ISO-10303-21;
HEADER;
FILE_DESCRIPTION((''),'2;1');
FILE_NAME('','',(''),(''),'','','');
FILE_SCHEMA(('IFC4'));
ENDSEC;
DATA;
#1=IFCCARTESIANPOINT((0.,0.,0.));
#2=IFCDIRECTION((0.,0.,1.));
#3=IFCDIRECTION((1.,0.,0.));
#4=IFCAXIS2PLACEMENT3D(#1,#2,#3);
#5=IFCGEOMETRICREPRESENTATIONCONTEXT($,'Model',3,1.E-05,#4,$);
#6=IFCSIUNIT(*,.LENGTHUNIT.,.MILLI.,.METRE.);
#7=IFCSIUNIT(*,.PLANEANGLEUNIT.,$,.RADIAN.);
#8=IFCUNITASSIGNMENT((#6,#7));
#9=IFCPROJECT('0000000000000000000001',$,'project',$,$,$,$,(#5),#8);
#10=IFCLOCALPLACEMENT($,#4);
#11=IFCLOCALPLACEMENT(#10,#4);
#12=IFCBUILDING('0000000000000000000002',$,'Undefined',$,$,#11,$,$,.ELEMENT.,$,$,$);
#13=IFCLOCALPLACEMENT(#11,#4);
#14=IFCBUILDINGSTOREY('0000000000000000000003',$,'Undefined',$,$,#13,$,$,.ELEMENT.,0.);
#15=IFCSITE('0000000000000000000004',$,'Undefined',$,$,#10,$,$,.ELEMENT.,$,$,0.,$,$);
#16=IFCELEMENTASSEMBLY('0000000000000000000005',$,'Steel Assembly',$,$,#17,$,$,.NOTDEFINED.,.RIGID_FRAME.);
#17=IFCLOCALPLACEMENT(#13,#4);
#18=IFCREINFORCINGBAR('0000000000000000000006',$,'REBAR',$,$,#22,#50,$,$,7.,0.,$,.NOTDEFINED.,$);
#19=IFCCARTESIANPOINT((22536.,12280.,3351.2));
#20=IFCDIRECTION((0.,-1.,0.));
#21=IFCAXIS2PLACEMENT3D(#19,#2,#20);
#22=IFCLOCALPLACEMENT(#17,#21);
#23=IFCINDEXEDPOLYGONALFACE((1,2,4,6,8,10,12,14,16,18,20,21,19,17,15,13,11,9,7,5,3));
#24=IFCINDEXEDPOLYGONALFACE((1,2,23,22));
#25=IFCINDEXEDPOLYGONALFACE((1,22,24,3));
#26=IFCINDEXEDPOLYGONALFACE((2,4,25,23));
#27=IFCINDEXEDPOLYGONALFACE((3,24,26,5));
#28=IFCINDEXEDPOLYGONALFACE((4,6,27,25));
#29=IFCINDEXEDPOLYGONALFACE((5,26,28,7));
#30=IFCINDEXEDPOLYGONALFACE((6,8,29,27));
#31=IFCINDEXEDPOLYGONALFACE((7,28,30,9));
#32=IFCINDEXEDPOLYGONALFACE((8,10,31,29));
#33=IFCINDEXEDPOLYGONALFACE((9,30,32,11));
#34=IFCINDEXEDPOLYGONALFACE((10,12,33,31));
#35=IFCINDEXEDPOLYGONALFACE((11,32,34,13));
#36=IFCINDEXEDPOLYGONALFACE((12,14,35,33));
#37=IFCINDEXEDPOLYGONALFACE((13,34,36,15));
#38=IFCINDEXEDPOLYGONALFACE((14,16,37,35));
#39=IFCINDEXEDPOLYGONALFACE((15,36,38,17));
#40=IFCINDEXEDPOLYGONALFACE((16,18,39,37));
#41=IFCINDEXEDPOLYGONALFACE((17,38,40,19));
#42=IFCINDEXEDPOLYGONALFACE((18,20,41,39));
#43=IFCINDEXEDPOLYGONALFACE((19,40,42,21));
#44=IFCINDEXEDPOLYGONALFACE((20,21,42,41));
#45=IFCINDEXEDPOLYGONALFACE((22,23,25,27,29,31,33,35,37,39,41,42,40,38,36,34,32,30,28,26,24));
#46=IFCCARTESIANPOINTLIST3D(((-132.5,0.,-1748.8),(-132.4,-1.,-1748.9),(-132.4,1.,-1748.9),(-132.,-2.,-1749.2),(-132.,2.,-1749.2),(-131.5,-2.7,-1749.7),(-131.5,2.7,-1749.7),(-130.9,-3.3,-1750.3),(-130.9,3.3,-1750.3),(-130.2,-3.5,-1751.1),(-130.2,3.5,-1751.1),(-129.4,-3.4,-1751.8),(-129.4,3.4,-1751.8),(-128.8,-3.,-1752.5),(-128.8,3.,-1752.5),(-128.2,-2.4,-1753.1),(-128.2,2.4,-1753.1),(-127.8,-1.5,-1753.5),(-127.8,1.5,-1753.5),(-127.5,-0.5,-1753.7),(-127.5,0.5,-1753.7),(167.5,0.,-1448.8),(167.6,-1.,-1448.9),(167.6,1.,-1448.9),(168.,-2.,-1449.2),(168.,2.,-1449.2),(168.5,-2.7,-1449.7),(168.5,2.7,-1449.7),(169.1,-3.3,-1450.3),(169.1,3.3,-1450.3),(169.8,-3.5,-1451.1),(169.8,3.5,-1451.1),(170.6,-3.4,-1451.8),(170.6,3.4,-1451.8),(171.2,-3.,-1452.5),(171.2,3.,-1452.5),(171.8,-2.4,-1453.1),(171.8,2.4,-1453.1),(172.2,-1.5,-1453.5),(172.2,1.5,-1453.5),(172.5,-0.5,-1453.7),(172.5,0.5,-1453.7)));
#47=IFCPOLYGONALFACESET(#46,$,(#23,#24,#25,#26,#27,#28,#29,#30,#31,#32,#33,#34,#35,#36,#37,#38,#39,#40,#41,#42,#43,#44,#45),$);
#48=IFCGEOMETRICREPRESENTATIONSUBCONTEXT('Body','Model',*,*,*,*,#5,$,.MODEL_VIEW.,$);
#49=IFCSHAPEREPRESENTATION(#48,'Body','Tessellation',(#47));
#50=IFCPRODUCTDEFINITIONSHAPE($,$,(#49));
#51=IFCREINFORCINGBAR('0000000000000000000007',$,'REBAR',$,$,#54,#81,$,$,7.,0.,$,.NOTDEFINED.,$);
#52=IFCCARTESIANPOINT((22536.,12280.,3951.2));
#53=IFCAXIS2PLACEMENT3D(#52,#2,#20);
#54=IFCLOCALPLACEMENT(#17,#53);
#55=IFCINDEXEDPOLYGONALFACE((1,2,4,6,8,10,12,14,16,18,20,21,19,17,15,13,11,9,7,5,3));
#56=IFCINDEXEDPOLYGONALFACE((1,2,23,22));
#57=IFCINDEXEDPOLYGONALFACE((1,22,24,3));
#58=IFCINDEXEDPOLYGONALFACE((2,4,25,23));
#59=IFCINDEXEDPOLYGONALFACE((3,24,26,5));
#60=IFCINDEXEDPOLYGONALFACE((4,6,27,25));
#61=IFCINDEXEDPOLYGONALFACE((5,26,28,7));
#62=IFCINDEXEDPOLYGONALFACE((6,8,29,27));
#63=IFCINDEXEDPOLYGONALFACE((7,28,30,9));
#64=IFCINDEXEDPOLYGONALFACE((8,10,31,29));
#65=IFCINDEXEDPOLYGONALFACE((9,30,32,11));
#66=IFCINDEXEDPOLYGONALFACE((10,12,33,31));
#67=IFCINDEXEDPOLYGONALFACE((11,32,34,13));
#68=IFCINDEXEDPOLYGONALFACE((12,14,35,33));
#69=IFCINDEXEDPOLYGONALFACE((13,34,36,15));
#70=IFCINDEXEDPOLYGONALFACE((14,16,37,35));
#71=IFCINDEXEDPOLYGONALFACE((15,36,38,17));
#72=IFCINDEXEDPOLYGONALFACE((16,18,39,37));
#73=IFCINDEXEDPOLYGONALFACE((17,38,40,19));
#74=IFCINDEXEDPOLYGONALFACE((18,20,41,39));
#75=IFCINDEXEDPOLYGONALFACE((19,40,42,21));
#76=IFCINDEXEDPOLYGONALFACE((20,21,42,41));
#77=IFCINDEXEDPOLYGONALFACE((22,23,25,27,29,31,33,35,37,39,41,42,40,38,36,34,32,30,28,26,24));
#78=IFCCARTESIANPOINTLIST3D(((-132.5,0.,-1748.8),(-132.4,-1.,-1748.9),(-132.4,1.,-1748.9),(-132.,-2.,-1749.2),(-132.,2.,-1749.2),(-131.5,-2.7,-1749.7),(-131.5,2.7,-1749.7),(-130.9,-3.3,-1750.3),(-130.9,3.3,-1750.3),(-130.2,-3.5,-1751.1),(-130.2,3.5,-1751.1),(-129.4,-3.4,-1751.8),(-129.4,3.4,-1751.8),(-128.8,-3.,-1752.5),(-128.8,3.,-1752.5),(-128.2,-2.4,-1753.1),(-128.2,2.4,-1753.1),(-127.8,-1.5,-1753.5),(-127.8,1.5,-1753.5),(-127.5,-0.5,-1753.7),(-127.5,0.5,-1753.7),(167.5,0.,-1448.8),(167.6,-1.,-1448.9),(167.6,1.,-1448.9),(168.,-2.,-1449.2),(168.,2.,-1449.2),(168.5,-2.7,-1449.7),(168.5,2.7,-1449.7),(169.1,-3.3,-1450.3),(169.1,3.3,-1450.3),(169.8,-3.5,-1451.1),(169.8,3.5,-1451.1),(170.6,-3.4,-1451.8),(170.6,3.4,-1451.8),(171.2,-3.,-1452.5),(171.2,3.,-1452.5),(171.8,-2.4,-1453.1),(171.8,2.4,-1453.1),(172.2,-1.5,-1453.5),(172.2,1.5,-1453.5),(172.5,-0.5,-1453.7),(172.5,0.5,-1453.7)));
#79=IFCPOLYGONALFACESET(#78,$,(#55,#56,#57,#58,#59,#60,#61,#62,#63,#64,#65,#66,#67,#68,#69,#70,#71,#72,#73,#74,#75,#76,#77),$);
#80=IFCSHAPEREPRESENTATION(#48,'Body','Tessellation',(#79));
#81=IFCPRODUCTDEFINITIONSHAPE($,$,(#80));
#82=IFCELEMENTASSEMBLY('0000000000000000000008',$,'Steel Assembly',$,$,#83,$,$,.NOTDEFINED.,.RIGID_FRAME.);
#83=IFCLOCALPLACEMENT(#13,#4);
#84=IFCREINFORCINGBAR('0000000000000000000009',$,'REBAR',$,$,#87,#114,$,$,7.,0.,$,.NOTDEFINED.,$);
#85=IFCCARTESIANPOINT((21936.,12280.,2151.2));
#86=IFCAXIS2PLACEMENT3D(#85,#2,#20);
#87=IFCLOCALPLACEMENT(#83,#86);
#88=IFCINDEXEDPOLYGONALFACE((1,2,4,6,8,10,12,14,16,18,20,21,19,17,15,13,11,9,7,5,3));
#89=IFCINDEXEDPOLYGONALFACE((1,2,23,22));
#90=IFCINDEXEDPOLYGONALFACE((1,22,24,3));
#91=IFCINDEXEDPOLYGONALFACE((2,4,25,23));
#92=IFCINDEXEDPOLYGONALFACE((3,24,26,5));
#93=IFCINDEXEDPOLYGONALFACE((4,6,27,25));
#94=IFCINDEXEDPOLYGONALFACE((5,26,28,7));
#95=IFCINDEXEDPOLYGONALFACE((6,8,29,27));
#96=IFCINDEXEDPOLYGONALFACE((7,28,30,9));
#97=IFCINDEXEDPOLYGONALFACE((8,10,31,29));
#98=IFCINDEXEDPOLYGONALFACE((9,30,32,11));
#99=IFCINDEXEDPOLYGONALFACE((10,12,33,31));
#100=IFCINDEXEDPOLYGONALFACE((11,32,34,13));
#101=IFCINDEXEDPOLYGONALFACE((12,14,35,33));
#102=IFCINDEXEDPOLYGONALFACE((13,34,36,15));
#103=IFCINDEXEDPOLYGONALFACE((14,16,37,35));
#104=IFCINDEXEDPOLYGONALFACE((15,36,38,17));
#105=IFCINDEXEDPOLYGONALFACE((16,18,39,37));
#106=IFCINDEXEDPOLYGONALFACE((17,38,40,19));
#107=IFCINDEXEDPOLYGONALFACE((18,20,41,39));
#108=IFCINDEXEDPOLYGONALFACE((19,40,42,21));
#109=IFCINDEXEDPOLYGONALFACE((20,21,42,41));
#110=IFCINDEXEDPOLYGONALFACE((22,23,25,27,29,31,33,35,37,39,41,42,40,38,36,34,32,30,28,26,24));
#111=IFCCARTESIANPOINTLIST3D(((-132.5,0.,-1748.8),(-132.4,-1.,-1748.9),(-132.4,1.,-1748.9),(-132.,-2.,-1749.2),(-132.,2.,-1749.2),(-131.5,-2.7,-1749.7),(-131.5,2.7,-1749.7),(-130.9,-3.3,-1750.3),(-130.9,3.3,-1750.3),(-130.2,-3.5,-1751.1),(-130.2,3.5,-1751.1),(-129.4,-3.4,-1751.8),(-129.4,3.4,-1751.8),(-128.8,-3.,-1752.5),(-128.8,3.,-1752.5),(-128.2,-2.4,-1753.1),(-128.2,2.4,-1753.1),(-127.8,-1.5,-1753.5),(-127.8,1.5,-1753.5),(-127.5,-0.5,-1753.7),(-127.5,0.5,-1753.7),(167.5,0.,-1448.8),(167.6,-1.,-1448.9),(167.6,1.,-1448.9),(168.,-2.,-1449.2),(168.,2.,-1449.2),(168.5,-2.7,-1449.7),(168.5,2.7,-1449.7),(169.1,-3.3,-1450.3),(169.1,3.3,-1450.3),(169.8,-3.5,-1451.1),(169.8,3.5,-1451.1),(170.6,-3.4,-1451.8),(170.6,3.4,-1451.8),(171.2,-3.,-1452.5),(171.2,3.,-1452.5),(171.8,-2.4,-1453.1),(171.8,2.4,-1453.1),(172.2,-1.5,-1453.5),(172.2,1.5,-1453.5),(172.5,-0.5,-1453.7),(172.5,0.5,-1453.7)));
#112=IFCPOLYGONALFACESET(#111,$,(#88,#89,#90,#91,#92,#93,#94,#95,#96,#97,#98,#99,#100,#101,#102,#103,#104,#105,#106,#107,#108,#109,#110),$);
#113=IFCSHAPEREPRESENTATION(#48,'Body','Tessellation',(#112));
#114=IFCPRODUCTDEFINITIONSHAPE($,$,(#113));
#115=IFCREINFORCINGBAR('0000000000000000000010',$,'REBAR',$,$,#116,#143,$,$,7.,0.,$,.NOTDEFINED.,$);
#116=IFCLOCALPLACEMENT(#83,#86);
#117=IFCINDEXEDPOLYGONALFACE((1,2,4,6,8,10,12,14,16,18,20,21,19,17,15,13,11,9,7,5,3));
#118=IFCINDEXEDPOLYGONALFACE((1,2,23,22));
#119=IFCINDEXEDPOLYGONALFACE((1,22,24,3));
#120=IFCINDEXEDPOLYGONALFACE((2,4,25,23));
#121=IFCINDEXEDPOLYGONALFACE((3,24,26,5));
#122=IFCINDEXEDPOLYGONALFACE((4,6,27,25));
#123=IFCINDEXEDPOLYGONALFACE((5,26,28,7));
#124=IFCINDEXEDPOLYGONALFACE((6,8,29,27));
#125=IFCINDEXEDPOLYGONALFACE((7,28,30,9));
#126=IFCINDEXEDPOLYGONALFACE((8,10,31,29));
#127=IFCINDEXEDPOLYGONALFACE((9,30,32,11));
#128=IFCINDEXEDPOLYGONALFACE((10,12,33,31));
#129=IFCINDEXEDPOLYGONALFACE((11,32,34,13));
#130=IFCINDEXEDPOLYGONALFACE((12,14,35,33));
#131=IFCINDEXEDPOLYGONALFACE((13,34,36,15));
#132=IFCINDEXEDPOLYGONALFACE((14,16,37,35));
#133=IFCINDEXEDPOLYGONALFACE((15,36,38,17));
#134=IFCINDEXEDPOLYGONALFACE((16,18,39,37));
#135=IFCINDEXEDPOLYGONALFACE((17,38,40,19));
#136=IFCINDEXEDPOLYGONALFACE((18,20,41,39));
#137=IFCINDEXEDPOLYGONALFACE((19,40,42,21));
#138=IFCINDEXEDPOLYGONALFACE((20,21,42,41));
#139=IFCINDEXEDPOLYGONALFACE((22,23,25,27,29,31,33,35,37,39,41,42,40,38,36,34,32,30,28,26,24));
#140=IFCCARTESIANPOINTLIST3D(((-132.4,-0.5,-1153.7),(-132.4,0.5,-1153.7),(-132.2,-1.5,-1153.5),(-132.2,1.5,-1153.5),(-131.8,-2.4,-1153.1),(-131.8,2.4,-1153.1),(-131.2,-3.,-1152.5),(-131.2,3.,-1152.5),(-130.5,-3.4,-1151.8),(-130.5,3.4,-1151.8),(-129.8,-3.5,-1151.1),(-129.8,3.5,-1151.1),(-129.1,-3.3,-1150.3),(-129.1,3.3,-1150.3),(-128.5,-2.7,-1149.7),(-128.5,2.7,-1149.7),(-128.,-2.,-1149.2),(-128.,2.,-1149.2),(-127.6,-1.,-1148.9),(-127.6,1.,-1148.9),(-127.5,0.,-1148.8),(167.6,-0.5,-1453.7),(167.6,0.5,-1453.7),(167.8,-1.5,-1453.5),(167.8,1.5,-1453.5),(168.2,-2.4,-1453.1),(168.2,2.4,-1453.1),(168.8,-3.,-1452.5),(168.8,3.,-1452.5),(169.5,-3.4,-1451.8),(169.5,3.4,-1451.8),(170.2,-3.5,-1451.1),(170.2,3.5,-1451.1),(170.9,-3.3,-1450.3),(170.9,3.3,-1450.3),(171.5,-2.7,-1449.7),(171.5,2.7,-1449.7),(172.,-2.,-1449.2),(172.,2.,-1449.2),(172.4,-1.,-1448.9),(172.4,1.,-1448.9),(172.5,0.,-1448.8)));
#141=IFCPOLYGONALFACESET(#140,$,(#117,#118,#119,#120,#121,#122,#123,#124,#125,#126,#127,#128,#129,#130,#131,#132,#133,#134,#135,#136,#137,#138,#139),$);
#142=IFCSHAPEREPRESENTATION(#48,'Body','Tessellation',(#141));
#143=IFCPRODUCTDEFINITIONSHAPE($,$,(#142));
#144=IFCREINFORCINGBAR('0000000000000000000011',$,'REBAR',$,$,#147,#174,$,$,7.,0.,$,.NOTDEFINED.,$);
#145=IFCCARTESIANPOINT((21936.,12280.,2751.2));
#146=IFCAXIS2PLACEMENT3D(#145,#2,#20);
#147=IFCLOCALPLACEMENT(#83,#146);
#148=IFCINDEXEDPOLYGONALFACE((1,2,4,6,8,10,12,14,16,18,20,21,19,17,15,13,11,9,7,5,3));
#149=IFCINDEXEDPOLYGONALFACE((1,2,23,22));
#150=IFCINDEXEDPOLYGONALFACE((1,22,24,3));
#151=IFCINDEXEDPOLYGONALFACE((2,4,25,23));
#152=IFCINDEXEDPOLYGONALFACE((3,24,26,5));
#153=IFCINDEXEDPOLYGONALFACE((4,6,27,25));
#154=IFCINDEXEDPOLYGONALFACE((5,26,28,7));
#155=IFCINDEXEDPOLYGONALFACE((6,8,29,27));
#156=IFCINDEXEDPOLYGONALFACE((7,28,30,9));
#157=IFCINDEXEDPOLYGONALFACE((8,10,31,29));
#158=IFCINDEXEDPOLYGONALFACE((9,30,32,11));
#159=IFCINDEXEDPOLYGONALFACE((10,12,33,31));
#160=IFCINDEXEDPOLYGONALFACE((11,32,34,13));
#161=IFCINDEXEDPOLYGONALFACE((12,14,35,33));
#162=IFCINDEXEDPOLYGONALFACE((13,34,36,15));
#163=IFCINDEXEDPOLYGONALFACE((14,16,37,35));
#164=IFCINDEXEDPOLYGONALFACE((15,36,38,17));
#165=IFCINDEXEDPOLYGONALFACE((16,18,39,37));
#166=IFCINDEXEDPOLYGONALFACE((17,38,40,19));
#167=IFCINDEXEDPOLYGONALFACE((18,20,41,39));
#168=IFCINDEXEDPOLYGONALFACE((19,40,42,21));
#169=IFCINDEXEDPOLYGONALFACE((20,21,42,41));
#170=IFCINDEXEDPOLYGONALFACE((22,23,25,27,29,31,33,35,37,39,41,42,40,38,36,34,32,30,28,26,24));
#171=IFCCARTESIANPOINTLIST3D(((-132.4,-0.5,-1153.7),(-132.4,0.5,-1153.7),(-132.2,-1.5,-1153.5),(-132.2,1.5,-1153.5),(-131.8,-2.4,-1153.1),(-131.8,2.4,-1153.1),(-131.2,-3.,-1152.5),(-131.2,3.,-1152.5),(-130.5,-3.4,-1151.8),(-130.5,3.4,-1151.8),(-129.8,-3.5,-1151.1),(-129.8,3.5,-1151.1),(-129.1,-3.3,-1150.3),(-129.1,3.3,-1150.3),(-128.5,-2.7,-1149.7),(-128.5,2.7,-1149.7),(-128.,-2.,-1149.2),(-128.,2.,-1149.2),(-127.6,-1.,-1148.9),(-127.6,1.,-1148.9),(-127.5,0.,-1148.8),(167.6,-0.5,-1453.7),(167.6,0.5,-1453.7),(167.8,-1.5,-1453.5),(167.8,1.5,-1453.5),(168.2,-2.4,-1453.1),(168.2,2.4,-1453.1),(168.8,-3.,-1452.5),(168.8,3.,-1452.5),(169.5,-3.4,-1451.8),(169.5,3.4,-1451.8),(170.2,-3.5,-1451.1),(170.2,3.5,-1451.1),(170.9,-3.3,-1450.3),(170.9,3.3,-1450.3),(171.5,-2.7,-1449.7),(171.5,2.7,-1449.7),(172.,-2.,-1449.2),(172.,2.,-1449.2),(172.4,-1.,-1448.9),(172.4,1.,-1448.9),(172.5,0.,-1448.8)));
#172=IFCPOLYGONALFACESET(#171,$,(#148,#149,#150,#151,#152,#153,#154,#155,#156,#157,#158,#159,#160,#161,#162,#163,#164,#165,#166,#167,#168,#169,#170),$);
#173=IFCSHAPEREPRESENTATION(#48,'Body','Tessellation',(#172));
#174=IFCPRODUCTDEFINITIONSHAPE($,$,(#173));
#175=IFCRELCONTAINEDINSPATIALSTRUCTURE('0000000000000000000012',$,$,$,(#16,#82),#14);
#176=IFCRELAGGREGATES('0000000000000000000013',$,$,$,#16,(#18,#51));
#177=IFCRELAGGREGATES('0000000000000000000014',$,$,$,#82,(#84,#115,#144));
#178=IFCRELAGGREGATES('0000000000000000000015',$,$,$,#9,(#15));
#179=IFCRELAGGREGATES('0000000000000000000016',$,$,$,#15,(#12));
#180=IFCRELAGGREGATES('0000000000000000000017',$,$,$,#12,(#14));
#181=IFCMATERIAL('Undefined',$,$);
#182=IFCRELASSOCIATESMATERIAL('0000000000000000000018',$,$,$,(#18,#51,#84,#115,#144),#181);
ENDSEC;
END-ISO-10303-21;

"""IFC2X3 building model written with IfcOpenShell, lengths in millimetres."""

from ifc_helpers import new_model, entity, si_unit, frame, origin_with_axes, place, context, subcontext, project, spatial, source, transform, mapped, material, element, aggregate, save


model = new_model("IFC2X3")

# Units and contexts
model_context = context("Model", 3, precision=1e-05, world=origin_with_axes())
body_context = subcontext(model_context, "Body", "Model", "MODEL_VIEW")
ifc_project = project(units=[si_unit("LENGTHUNIT", "METRE", prefix="MILLI"), si_unit("PLANEANGLEUNIT", "RADIAN")], contexts=[model_context])

# Site, building, storey
site_placement = place(None, origin_with_axes())
site = spatial("IfcSite", under=ifc_project, at=site_placement, Name="Undefined", CompositionType="ELEMENT", RefElevation=0.0)
building_placement = place(site_placement, origin_with_axes())
building = spatial("IfcBuilding", under=site, at=building_placement, Name="Undefined", CompositionType="ELEMENT")
storey_placement = place(building_placement, origin_with_axes())
storey = spatial("IfcBuildingStorey", under=building, at=storey_placement, Name="Undefined", CompositionType="ELEMENT", Elevation=0.0)

# Shared definitions
ifc_material_1 = material(Name="Undefined")

# Element assemblies, reinforcing bars
assembly_1_placement = place(storey_placement, origin_with_axes())
assembly_1 = element("IfcElementAssembly", 1, at=assembly_1_placement, inside=storey, Name="Steel Assembly", AssemblyPlace="NOTDEFINED", PredefinedType="RIGID_FRAME")
shared_shape_1 = source(origin_with_axes(), body_context, "Body", "AdvancedSweptSolid", [
    entity("IfcSweptDiskSolid", entity("IfcTrimmedCurve", entity("IfcLine", entity("IfcCartesianPoint", [0.0, 0.0, 0.0]), entity("IfcVector", entity("IfcDirection", [0.707107, 0.0, 0.707107]), 1.0)), [entity("IfcParameterValue", 0.0)], [entity("IfcParameterValue", 424.264069)], True, "PARAMETER"), 3.5, None, 0.0, 424.3),
])
reinforcing_bar_1_placement = place(assembly_1_placement, frame((22536.0, 12280.0, 3351.2), z_axis=(0.0, 0.0, 1.0), x_axis=(0.0, -1.0, 0.0)))
reinforcing_bar_1 = element("IfcReinforcingBar", 2, at=reinforcing_bar_1_placement, material=ifc_material_1, Name="REBAR", BarRole="NOTDEFINED", CrossSectionArea=0.0, NominalDiameter=7.0, context=body_context, shape_type="MappedRepresentation", body=[
    mapped(shared_shape_1, transform((-130.0, 0.0, -1751.2))),
])
shared_shape_2 = source(origin_with_axes(), body_context, "Body", "AdvancedSweptSolid", [
    entity("IfcSweptDiskSolid", entity("IfcTrimmedCurve", entity("IfcLine", entity("IfcCartesianPoint", [0.0, 0.0, 0.0]), entity("IfcVector", entity("IfcDirection", [0.707107, 0.0, 0.707107]), 1.0)), [entity("IfcParameterValue", 0.0)], [entity("IfcParameterValue", 424.264069)], True, "PARAMETER"), 3.5, None, 0.0, 424.3),
])
reinforcing_bar_2_placement = place(assembly_1_placement, frame((22536.0, 12280.0, 3951.2), z_axis=(0.0, 0.0, 1.0), x_axis=(0.0, -1.0, 0.0)))
reinforcing_bar_2 = element("IfcReinforcingBar", 3, at=reinforcing_bar_2_placement, material=ifc_material_1, Name="REBAR", BarRole="NOTDEFINED", CrossSectionArea=0.0, NominalDiameter=7.0, context=body_context, shape_type="MappedRepresentation", body=[
    mapped(shared_shape_2, transform((-130.0, 0.0, -1751.2))),
])
aggregate(assembly_1, [reinforcing_bar_1, reinforcing_bar_2])
assembly_2_placement = place(storey_placement, origin_with_axes())
assembly_2 = element("IfcElementAssembly", 4, at=assembly_2_placement, inside=storey, Name="Steel Assembly", AssemblyPlace="NOTDEFINED", PredefinedType="RIGID_FRAME")
shared_shape_3 = source(origin_with_axes(), body_context, "Body", "AdvancedSweptSolid", [
    entity("IfcSweptDiskSolid", entity("IfcTrimmedCurve", entity("IfcLine", entity("IfcCartesianPoint", [0.0, 0.0, 0.0]), entity("IfcVector", entity("IfcDirection", [0.707107, 0.0, 0.707107]), 1.0)), [entity("IfcParameterValue", 0.0)], [entity("IfcParameterValue", 424.264069)], True, "PARAMETER"), 3.5, None, 0.0, 424.3),
])
reinforcing_bar_3_placement = place(assembly_2_placement, frame((21936.0, 12280.0, 2151.2), z_axis=(0.0, 0.0, 1.0), x_axis=(0.0, -1.0, 0.0)))
reinforcing_bar_3 = element("IfcReinforcingBar", 5, at=reinforcing_bar_3_placement, material=ifc_material_1, Name="REBAR", BarRole="NOTDEFINED", CrossSectionArea=0.0, NominalDiameter=7.0, context=body_context, shape_type="MappedRepresentation", body=[
    mapped(shared_shape_3, transform((-130.0, 0.0, -1751.2))),
])
shared_shape_4 = source(origin_with_axes(), body_context, "Body", "AdvancedSweptSolid", [
    entity("IfcSweptDiskSolid", entity("IfcTrimmedCurve", entity("IfcLine", entity("IfcCartesianPoint", [0.0, 0.0, 0.0]), entity("IfcVector", entity("IfcDirection", [0.707107, 0.0, -0.707107]), 1.0)), [entity("IfcParameterValue", 0.0)], [entity("IfcParameterValue", 424.264069)], True, "PARAMETER"), 3.5, None, 0.0, 424.3),
])
reinforcing_bar_4_placement = place(assembly_2_placement, frame((21936.0, 12280.0, 2151.2), z_axis=(0.0, 0.0, 1.0), x_axis=(0.0, -1.0, 0.0)))
reinforcing_bar_4 = element("IfcReinforcingBar", 6, at=reinforcing_bar_4_placement, material=ifc_material_1, Name="REBAR", BarRole="NOTDEFINED", CrossSectionArea=0.0, NominalDiameter=7.0, context=body_context, shape_type="MappedRepresentation", body=[
    mapped(shared_shape_4, transform((-130.0, 0.0, -1151.2))),
])
shared_shape_5 = source(origin_with_axes(), body_context, "Body", "AdvancedSweptSolid", [
    entity("IfcSweptDiskSolid", entity("IfcTrimmedCurve", entity("IfcLine", entity("IfcCartesianPoint", [0.0, 0.0, 0.0]), entity("IfcVector", entity("IfcDirection", [0.707107, 0.0, -0.707107]), 1.0)), [entity("IfcParameterValue", 0.0)], [entity("IfcParameterValue", 424.264069)], True, "PARAMETER"), 3.5, None, 0.0, 424.3),
])
reinforcing_bar_5_placement = place(assembly_2_placement, frame((21936.0, 12280.0, 2751.2), z_axis=(0.0, 0.0, 1.0), x_axis=(0.0, -1.0, 0.0)))
reinforcing_bar_5 = element("IfcReinforcingBar", 7, at=reinforcing_bar_5_placement, material=ifc_material_1, Name="REBAR", BarRole="NOTDEFINED", CrossSectionArea=0.0, NominalDiameter=7.0, context=body_context, shape_type="MappedRepresentation", body=[
    mapped(shared_shape_5, transform((-130.0, 0.0, -1151.2))),
])
aggregate(assembly_2, [reinforcing_bar_3, reinforcing_bar_4, reinforcing_bar_5])

save(model, "model.ifc")
